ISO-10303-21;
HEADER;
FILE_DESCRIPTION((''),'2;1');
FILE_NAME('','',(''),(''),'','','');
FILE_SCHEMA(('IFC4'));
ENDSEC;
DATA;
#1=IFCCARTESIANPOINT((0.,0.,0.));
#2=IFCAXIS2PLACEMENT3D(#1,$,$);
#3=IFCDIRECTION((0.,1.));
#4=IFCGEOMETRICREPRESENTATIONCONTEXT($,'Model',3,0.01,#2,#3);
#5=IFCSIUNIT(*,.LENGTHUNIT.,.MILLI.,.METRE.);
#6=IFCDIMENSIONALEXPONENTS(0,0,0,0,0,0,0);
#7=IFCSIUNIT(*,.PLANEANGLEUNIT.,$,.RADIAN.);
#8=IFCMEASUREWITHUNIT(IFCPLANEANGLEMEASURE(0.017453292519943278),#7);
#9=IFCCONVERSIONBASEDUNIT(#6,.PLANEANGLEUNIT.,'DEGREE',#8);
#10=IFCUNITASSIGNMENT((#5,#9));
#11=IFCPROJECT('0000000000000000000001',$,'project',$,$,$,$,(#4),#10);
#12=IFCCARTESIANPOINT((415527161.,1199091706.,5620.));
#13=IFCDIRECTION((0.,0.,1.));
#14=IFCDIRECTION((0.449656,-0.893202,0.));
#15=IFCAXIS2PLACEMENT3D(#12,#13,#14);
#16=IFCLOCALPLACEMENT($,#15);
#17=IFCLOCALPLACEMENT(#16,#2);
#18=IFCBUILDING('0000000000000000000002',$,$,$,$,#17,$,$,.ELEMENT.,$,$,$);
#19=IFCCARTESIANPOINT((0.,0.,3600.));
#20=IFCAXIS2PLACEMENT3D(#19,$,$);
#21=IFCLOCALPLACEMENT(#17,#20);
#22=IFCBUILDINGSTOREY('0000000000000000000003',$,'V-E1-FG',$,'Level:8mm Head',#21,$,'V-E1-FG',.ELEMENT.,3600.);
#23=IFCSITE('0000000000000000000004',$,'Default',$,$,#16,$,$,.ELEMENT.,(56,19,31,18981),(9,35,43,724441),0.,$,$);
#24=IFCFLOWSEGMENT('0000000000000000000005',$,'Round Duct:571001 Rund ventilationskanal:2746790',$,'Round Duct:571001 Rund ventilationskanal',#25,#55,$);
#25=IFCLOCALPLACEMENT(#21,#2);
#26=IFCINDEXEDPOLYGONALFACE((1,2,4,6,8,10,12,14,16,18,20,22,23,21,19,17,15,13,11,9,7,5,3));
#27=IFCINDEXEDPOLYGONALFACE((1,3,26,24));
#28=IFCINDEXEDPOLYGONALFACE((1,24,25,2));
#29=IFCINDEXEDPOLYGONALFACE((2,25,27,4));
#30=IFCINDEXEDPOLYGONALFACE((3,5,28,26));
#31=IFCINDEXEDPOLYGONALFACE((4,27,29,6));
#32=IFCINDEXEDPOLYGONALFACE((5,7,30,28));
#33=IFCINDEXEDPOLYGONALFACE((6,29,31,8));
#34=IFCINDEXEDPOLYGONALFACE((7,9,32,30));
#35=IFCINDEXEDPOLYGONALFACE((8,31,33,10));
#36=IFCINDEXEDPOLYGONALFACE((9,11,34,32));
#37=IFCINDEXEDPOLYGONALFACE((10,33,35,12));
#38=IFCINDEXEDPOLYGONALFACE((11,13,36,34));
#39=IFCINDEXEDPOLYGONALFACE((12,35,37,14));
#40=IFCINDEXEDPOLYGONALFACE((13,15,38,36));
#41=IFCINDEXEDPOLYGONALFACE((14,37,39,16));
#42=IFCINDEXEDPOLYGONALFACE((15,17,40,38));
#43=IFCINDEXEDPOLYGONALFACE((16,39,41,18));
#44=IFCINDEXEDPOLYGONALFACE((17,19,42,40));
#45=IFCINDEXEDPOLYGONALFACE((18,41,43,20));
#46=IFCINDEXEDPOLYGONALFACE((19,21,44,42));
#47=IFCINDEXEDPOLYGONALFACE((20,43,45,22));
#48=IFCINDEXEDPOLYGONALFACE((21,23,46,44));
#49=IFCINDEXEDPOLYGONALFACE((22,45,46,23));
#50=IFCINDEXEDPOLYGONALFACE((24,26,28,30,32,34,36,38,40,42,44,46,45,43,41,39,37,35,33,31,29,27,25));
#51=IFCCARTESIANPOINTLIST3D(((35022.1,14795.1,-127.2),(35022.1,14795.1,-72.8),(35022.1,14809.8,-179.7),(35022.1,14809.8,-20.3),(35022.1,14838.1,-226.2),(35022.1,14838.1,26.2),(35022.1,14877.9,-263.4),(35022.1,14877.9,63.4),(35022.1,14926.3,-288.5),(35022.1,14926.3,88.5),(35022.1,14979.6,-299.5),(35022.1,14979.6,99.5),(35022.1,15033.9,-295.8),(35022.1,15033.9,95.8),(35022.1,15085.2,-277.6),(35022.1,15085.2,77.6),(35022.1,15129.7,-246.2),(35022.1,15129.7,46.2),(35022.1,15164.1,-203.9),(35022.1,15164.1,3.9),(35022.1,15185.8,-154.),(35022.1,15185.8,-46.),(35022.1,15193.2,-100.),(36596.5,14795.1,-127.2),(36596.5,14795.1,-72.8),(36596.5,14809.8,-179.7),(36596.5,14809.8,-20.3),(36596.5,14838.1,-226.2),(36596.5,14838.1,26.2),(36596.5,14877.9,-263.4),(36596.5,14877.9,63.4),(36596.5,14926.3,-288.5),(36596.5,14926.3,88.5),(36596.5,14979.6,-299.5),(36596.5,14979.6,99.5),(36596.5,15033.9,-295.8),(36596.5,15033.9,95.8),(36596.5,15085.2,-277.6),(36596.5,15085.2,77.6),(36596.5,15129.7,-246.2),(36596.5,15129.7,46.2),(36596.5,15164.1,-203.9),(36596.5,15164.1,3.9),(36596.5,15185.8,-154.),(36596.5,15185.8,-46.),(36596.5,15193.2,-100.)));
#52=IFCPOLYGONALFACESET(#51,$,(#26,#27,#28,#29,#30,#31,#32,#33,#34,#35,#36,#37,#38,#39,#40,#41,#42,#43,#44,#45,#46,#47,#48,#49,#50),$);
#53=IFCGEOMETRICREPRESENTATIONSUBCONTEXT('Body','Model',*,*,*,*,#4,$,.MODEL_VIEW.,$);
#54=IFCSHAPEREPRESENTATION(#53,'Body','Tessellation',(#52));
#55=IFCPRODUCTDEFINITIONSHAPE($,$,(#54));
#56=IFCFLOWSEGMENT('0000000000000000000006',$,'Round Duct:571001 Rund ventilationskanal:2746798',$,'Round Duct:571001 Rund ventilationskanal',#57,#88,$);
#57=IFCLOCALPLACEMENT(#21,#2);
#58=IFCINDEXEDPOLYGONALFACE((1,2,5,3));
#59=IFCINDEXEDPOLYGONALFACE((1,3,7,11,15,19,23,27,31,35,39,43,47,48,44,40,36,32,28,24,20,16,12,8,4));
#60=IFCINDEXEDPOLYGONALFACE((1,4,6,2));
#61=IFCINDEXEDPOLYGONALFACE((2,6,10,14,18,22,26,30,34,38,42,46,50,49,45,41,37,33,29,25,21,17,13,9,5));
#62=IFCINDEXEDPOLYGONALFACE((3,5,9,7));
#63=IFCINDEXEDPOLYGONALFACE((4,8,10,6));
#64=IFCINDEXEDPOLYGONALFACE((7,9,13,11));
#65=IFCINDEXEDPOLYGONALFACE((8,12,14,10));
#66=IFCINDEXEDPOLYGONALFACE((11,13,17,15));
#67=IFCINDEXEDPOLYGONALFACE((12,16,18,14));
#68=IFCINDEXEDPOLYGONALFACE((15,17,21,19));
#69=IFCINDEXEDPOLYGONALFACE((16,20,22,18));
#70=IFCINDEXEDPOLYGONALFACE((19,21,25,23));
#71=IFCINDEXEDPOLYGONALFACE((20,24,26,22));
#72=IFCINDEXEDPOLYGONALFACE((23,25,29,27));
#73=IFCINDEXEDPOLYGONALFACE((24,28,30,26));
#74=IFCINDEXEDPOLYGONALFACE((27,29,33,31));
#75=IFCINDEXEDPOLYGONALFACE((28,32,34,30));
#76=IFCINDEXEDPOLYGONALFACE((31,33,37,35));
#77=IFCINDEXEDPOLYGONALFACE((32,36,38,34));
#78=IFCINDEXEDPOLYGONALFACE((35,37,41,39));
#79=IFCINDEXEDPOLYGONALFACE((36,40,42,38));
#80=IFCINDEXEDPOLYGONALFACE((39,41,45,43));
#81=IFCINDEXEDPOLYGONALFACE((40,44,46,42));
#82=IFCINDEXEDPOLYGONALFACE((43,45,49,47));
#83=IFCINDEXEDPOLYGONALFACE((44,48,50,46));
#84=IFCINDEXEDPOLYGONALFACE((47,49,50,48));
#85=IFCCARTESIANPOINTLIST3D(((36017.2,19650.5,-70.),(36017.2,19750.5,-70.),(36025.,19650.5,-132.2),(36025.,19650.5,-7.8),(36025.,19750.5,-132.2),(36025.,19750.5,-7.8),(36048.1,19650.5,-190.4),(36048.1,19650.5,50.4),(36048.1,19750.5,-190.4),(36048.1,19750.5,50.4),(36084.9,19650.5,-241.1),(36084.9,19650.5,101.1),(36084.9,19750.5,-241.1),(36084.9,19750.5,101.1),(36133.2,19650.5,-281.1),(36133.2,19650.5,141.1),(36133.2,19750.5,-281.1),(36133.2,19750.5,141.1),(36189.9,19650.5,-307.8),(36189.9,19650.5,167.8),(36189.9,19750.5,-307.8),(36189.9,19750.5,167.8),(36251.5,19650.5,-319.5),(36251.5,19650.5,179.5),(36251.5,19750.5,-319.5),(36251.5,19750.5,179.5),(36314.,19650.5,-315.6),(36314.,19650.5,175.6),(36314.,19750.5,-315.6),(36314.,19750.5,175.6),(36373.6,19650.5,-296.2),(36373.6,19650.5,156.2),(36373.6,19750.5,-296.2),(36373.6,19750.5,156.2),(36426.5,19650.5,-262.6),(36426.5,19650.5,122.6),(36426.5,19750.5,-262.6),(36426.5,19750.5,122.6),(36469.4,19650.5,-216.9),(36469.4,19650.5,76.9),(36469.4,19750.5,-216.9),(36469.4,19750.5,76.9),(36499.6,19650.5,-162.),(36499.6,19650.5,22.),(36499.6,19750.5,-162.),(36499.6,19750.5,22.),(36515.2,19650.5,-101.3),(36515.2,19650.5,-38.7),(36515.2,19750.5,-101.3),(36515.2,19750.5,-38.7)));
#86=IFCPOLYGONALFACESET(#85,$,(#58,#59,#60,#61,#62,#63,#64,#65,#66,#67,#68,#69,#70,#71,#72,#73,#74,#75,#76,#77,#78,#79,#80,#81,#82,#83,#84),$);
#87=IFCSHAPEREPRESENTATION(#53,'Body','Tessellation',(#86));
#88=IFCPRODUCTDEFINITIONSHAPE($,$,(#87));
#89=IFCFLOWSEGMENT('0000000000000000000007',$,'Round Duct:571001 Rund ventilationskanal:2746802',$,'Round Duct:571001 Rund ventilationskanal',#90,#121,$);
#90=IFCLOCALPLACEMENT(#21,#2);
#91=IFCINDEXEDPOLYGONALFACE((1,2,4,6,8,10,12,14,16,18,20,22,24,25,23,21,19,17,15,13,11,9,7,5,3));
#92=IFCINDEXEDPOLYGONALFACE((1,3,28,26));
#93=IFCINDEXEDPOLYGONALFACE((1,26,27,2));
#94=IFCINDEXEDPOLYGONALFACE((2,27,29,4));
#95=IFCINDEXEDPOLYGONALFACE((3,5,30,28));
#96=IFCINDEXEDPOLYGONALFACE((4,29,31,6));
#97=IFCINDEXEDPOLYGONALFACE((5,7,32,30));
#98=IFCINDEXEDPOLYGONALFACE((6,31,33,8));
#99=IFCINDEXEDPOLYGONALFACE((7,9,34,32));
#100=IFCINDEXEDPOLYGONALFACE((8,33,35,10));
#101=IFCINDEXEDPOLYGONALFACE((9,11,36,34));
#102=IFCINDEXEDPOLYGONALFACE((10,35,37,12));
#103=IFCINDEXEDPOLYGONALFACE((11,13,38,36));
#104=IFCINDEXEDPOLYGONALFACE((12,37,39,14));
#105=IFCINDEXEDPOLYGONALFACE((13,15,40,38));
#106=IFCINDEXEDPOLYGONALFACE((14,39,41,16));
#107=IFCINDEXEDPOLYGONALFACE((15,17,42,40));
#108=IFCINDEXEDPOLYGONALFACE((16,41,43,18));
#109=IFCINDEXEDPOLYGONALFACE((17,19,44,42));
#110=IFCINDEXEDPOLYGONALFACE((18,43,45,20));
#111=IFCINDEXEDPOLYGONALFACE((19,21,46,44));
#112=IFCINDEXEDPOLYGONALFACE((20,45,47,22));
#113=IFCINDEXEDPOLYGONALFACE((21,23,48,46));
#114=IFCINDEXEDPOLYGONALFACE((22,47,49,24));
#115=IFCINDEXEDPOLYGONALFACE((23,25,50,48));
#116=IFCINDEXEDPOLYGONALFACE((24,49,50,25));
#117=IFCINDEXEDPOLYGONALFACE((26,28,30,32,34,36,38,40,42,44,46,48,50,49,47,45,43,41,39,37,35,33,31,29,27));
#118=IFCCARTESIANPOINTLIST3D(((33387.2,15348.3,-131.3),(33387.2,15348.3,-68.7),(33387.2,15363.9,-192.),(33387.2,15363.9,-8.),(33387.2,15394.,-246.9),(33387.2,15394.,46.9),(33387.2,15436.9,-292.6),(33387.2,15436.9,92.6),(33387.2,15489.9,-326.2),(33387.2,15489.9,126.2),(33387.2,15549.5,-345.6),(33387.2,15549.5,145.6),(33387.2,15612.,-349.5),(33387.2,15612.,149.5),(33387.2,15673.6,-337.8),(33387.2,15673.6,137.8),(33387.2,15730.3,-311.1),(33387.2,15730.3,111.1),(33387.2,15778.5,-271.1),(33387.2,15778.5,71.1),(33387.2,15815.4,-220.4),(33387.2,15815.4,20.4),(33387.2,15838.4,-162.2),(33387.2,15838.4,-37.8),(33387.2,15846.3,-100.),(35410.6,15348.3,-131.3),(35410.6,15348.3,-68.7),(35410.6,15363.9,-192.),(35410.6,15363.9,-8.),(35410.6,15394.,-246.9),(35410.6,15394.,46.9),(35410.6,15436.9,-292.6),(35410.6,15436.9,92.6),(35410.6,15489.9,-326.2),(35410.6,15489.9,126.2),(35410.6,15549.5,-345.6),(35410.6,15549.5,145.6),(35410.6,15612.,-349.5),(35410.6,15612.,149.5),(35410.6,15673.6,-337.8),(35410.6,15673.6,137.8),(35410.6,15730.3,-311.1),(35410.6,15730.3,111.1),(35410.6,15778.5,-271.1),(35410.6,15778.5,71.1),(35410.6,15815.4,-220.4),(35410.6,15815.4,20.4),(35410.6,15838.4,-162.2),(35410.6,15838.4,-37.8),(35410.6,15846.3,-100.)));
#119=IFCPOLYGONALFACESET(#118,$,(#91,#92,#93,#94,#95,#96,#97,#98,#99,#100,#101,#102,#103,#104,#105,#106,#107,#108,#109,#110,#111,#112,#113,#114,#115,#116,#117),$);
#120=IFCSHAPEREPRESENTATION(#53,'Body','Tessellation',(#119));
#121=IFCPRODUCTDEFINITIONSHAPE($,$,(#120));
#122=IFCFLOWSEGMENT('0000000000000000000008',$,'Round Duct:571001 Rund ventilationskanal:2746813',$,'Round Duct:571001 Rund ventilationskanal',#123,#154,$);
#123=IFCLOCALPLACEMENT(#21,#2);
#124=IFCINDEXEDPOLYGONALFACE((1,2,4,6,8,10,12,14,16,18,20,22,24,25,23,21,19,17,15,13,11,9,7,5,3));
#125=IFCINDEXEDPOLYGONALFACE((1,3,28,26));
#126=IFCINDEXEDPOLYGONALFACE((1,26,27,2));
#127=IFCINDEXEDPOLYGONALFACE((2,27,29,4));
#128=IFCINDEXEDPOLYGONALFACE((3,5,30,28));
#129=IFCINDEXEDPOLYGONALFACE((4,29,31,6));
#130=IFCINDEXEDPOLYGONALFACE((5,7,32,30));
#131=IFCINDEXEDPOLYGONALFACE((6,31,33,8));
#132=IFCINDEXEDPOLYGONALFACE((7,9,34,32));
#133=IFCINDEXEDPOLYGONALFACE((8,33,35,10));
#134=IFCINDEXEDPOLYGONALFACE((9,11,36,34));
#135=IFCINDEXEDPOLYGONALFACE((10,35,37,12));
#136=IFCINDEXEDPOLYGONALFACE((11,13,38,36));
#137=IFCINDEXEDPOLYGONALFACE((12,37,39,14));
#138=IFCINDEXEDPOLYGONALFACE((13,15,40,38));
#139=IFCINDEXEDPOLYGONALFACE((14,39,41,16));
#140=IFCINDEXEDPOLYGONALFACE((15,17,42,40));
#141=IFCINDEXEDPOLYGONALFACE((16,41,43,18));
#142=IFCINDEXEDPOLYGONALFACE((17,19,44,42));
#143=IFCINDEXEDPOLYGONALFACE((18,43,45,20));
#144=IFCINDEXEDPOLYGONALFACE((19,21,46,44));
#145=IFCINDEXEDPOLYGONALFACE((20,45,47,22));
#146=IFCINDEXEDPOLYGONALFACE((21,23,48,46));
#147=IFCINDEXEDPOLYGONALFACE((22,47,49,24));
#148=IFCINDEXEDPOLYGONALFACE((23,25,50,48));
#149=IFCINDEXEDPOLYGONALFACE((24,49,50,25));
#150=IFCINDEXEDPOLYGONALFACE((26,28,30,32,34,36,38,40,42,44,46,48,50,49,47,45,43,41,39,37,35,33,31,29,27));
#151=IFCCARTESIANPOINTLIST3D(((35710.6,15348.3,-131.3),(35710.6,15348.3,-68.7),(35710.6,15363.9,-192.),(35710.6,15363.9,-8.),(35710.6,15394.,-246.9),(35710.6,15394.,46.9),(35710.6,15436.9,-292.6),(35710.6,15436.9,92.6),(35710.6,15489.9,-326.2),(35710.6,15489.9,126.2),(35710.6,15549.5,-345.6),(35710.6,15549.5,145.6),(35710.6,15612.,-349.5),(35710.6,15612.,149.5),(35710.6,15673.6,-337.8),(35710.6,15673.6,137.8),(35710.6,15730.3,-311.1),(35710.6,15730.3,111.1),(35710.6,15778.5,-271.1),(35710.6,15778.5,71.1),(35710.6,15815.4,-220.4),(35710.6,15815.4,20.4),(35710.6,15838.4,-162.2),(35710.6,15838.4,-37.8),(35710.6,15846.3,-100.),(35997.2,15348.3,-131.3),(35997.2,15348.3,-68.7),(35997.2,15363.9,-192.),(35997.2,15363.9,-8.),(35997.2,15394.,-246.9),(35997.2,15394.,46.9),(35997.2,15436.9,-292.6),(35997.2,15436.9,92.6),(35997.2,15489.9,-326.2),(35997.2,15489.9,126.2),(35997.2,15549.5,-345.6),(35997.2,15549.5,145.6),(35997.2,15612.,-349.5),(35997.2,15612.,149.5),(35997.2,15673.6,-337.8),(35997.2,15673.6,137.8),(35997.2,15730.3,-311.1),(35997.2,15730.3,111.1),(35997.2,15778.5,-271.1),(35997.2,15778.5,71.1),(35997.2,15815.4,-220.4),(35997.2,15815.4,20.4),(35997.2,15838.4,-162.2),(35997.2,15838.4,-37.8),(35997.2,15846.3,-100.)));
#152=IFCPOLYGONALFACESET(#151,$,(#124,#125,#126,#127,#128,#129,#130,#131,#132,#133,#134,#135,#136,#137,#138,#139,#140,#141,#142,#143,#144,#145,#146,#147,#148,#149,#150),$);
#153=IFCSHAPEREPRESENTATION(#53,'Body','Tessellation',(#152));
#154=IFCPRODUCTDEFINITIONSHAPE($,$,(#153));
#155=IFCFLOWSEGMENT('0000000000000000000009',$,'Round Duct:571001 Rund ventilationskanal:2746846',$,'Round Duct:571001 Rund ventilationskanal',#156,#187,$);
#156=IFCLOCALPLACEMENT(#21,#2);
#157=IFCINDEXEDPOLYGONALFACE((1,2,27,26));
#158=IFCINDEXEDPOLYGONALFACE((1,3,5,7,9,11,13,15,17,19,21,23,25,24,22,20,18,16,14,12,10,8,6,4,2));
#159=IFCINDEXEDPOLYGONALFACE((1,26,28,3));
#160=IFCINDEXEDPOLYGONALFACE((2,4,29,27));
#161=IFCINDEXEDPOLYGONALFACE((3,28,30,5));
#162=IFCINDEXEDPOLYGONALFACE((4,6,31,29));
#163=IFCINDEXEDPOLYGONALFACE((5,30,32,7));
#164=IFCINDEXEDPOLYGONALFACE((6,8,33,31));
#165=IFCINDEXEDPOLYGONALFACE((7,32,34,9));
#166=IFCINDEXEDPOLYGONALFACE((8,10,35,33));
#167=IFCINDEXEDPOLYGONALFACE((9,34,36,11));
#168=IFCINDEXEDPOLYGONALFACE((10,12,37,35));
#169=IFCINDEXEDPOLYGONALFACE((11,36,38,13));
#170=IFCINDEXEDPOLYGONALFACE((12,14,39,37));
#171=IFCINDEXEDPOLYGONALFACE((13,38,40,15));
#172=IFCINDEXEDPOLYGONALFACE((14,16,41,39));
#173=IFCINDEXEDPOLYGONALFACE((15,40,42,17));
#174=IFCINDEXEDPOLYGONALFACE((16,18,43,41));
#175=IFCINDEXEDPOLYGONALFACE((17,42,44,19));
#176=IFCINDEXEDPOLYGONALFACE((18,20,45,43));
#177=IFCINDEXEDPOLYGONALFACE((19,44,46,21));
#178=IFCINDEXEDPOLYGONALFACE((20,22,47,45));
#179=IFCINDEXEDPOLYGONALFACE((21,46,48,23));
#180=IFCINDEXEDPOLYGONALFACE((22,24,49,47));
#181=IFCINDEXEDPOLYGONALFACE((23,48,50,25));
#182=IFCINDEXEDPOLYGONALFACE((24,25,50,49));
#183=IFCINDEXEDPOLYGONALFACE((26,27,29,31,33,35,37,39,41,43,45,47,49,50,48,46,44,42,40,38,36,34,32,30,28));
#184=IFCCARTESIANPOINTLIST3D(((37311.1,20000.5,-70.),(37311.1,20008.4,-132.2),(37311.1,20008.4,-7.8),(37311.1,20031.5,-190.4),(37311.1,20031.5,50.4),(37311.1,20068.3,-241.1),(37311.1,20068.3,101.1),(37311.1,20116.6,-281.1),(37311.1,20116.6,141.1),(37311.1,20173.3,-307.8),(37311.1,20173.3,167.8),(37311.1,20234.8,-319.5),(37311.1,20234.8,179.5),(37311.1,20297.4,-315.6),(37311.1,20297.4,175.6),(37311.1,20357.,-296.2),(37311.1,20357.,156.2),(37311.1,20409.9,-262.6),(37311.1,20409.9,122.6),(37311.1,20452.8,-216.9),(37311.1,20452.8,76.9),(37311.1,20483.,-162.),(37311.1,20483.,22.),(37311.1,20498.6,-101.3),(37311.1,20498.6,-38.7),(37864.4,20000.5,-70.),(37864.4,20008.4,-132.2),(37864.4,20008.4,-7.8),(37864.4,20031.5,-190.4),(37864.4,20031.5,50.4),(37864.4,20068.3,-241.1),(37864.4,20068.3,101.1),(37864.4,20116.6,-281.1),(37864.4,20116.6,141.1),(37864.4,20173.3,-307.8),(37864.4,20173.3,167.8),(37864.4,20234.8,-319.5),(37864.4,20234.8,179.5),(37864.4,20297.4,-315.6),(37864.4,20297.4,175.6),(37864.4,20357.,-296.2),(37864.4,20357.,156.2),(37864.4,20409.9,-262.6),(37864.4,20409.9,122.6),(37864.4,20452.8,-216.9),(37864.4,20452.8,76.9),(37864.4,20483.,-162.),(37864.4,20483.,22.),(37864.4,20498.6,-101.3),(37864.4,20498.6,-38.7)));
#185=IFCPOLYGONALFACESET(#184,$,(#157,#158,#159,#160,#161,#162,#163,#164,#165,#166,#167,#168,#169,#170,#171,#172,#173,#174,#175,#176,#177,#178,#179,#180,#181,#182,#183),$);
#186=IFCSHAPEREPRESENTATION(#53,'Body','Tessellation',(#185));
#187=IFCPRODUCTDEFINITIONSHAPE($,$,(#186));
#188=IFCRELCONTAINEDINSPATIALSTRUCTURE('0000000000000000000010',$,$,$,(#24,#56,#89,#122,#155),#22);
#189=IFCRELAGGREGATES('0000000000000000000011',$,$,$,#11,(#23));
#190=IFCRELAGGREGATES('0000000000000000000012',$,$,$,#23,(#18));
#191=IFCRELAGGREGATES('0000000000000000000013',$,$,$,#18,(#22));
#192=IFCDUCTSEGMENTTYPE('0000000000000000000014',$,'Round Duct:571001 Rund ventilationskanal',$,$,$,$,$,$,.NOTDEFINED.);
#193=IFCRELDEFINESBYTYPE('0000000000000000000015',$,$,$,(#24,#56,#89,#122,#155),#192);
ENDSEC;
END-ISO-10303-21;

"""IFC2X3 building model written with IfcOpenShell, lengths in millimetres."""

from ifc_helpers import new_model, entity, si_unit, converted_unit, direction, frame, frame_2d, origin, place, context, subcontext, project, spatial, circle, extrude, type_object, element, save


model = new_model("IFC2X3")

# Units and contexts
model_context = context("Model", 3, precision=0.01, world=origin(), true_north=direction((0.0, 1.0)))
body_context = subcontext(model_context, "Body", "Model", "MODEL_VIEW")
ifc_project = project(units=[si_unit("LENGTHUNIT", "METRE", prefix="MILLI"), converted_unit("PLANEANGLEUNIT", "DEGREE", entity("IfcPlaneAngleMeasure", 0.017453292519943278), si_unit("PLANEANGLEUNIT", "RADIAN"), dimensions=[0, 0, 0, 0, 0, 0, 0])], contexts=[model_context])

# Site, building, storey
site_placement = place(None, frame((415527161.0, 1199091706.0, 5620.0), z_axis=(0.0, 0.0, 1.0), x_axis=(0.449656, -0.893202, 0.0)))
site = spatial("IfcSite", under=ifc_project, at=site_placement, Name="Default", CompositionType="ELEMENT", RefLatitude=(56, 19, 31, 18981), RefLongitude=(9, 35, 43, 724441), RefElevation=0.0)
building_placement = place(site_placement, origin())
building = spatial("IfcBuilding", under=site, at=building_placement, CompositionType="ELEMENT")
storey_placement = place(building_placement, frame((0.0, 0.0, 3600.0)))
storey = spatial("IfcBuildingStorey", under=building, at=storey_placement, Name="V-E1-FG", ObjectType="Level:8mm Head", LongName="V-E1-FG", CompositionType="ELEMENT", Elevation=3600.0)

# Flow segments
duct_segment_type = type_object("IfcDuctSegmentType", Name="Round Duct:571001 Rund ventilationskanal", PredefinedType="NOTDEFINED")
flow_segment_1_placement = place(storey_placement, origin())
element("IfcFlowSegment", 1, at=flow_segment_1_placement, inside=storey, type_object=duct_segment_type, Name="Round Duct:571001 Rund ventilationskanal:2746790", ObjectType="Round Duct:571001 Rund ventilationskanal", context=body_context, shape_type="SweptSolid", body=[
    extrude(circle(Radius=200.0, at=frame_2d((0.0, 0.0), x_axis=(1.0, 0.0))), frame((35022.1, 14993.2, -100.0), z_axis=(1.0, 0.0, 0.0), x_axis=(0.0, 1.0, 0.0)), (0.0, 0.0, 1.0), 1574.3),
])
flow_segment_2_placement = place(storey_placement, origin())
element("IfcFlowSegment", 2, at=flow_segment_2_placement, inside=storey, type_object=duct_segment_type, Name="Round Duct:571001 Rund ventilationskanal:2746798", ObjectType="Round Duct:571001 Rund ventilationskanal", context=body_context, shape_type="SweptSolid", body=[
    extrude(circle(Radius=250.0, at=frame_2d((0.0, 0.0), x_axis=(1.0, 0.0))), frame((36267.2, 19650.5, -70.0), z_axis=(0.0, 1.0, 0.0), x_axis=(-1.0, 0.0, 0.0)), (0.0, 0.0, 1.0), 100.0),
])
flow_segment_3_placement = place(storey_placement, origin())
element("IfcFlowSegment", 3, at=flow_segment_3_placement, inside=storey, type_object=duct_segment_type, Name="Round Duct:571001 Rund ventilationskanal:2746802", ObjectType="Round Duct:571001 Rund ventilationskanal", context=body_context, shape_type="SweptSolid", body=[
    extrude(circle(Radius=250.0, at=frame_2d((0.0, 0.0), x_axis=(1.0, 0.0))), frame((33387.2, 15596.3, -100.0), z_axis=(1.0, 0.0, 0.0), x_axis=(0.0, 1.0, 0.0)), (0.0, 0.0, 1.0), 2023.5),
])
flow_segment_4_placement = place(storey_placement, origin())
element("IfcFlowSegment", 4, at=flow_segment_4_placement, inside=storey, type_object=duct_segment_type, Name="Round Duct:571001 Rund ventilationskanal:2746813", ObjectType="Round Duct:571001 Rund ventilationskanal", context=body_context, shape_type="SweptSolid", body=[
    extrude(circle(Radius=250.0, at=frame_2d((0.0, 0.0), x_axis=(1.0, 0.0))), frame((35710.6, 15596.3, -100.0), z_axis=(1.0, 0.0, 0.0), x_axis=(0.0, 1.0, 0.0)), (0.0, 0.0, 1.0), 286.5),
])
flow_segment_5_placement = place(storey_placement, origin())
element("IfcFlowSegment", 5, at=flow_segment_5_placement, inside=storey, type_object=duct_segment_type, Name="Round Duct:571001 Rund ventilationskanal:2746846", ObjectType="Round Duct:571001 Rund ventilationskanal", context=body_context, shape_type="SweptSolid", body=[
    extrude(circle(Radius=250.0, at=frame_2d((0.0, 0.0), x_axis=(1.0, 0.0))), frame((37311.1, 20250.5, -70.0), z_axis=(1.0, 0.0, 0.0), x_axis=(0.0, -1.0, 0.0)), (0.0, 0.0, 1.0), 553.3),
])

save(model, "model.ifc")
